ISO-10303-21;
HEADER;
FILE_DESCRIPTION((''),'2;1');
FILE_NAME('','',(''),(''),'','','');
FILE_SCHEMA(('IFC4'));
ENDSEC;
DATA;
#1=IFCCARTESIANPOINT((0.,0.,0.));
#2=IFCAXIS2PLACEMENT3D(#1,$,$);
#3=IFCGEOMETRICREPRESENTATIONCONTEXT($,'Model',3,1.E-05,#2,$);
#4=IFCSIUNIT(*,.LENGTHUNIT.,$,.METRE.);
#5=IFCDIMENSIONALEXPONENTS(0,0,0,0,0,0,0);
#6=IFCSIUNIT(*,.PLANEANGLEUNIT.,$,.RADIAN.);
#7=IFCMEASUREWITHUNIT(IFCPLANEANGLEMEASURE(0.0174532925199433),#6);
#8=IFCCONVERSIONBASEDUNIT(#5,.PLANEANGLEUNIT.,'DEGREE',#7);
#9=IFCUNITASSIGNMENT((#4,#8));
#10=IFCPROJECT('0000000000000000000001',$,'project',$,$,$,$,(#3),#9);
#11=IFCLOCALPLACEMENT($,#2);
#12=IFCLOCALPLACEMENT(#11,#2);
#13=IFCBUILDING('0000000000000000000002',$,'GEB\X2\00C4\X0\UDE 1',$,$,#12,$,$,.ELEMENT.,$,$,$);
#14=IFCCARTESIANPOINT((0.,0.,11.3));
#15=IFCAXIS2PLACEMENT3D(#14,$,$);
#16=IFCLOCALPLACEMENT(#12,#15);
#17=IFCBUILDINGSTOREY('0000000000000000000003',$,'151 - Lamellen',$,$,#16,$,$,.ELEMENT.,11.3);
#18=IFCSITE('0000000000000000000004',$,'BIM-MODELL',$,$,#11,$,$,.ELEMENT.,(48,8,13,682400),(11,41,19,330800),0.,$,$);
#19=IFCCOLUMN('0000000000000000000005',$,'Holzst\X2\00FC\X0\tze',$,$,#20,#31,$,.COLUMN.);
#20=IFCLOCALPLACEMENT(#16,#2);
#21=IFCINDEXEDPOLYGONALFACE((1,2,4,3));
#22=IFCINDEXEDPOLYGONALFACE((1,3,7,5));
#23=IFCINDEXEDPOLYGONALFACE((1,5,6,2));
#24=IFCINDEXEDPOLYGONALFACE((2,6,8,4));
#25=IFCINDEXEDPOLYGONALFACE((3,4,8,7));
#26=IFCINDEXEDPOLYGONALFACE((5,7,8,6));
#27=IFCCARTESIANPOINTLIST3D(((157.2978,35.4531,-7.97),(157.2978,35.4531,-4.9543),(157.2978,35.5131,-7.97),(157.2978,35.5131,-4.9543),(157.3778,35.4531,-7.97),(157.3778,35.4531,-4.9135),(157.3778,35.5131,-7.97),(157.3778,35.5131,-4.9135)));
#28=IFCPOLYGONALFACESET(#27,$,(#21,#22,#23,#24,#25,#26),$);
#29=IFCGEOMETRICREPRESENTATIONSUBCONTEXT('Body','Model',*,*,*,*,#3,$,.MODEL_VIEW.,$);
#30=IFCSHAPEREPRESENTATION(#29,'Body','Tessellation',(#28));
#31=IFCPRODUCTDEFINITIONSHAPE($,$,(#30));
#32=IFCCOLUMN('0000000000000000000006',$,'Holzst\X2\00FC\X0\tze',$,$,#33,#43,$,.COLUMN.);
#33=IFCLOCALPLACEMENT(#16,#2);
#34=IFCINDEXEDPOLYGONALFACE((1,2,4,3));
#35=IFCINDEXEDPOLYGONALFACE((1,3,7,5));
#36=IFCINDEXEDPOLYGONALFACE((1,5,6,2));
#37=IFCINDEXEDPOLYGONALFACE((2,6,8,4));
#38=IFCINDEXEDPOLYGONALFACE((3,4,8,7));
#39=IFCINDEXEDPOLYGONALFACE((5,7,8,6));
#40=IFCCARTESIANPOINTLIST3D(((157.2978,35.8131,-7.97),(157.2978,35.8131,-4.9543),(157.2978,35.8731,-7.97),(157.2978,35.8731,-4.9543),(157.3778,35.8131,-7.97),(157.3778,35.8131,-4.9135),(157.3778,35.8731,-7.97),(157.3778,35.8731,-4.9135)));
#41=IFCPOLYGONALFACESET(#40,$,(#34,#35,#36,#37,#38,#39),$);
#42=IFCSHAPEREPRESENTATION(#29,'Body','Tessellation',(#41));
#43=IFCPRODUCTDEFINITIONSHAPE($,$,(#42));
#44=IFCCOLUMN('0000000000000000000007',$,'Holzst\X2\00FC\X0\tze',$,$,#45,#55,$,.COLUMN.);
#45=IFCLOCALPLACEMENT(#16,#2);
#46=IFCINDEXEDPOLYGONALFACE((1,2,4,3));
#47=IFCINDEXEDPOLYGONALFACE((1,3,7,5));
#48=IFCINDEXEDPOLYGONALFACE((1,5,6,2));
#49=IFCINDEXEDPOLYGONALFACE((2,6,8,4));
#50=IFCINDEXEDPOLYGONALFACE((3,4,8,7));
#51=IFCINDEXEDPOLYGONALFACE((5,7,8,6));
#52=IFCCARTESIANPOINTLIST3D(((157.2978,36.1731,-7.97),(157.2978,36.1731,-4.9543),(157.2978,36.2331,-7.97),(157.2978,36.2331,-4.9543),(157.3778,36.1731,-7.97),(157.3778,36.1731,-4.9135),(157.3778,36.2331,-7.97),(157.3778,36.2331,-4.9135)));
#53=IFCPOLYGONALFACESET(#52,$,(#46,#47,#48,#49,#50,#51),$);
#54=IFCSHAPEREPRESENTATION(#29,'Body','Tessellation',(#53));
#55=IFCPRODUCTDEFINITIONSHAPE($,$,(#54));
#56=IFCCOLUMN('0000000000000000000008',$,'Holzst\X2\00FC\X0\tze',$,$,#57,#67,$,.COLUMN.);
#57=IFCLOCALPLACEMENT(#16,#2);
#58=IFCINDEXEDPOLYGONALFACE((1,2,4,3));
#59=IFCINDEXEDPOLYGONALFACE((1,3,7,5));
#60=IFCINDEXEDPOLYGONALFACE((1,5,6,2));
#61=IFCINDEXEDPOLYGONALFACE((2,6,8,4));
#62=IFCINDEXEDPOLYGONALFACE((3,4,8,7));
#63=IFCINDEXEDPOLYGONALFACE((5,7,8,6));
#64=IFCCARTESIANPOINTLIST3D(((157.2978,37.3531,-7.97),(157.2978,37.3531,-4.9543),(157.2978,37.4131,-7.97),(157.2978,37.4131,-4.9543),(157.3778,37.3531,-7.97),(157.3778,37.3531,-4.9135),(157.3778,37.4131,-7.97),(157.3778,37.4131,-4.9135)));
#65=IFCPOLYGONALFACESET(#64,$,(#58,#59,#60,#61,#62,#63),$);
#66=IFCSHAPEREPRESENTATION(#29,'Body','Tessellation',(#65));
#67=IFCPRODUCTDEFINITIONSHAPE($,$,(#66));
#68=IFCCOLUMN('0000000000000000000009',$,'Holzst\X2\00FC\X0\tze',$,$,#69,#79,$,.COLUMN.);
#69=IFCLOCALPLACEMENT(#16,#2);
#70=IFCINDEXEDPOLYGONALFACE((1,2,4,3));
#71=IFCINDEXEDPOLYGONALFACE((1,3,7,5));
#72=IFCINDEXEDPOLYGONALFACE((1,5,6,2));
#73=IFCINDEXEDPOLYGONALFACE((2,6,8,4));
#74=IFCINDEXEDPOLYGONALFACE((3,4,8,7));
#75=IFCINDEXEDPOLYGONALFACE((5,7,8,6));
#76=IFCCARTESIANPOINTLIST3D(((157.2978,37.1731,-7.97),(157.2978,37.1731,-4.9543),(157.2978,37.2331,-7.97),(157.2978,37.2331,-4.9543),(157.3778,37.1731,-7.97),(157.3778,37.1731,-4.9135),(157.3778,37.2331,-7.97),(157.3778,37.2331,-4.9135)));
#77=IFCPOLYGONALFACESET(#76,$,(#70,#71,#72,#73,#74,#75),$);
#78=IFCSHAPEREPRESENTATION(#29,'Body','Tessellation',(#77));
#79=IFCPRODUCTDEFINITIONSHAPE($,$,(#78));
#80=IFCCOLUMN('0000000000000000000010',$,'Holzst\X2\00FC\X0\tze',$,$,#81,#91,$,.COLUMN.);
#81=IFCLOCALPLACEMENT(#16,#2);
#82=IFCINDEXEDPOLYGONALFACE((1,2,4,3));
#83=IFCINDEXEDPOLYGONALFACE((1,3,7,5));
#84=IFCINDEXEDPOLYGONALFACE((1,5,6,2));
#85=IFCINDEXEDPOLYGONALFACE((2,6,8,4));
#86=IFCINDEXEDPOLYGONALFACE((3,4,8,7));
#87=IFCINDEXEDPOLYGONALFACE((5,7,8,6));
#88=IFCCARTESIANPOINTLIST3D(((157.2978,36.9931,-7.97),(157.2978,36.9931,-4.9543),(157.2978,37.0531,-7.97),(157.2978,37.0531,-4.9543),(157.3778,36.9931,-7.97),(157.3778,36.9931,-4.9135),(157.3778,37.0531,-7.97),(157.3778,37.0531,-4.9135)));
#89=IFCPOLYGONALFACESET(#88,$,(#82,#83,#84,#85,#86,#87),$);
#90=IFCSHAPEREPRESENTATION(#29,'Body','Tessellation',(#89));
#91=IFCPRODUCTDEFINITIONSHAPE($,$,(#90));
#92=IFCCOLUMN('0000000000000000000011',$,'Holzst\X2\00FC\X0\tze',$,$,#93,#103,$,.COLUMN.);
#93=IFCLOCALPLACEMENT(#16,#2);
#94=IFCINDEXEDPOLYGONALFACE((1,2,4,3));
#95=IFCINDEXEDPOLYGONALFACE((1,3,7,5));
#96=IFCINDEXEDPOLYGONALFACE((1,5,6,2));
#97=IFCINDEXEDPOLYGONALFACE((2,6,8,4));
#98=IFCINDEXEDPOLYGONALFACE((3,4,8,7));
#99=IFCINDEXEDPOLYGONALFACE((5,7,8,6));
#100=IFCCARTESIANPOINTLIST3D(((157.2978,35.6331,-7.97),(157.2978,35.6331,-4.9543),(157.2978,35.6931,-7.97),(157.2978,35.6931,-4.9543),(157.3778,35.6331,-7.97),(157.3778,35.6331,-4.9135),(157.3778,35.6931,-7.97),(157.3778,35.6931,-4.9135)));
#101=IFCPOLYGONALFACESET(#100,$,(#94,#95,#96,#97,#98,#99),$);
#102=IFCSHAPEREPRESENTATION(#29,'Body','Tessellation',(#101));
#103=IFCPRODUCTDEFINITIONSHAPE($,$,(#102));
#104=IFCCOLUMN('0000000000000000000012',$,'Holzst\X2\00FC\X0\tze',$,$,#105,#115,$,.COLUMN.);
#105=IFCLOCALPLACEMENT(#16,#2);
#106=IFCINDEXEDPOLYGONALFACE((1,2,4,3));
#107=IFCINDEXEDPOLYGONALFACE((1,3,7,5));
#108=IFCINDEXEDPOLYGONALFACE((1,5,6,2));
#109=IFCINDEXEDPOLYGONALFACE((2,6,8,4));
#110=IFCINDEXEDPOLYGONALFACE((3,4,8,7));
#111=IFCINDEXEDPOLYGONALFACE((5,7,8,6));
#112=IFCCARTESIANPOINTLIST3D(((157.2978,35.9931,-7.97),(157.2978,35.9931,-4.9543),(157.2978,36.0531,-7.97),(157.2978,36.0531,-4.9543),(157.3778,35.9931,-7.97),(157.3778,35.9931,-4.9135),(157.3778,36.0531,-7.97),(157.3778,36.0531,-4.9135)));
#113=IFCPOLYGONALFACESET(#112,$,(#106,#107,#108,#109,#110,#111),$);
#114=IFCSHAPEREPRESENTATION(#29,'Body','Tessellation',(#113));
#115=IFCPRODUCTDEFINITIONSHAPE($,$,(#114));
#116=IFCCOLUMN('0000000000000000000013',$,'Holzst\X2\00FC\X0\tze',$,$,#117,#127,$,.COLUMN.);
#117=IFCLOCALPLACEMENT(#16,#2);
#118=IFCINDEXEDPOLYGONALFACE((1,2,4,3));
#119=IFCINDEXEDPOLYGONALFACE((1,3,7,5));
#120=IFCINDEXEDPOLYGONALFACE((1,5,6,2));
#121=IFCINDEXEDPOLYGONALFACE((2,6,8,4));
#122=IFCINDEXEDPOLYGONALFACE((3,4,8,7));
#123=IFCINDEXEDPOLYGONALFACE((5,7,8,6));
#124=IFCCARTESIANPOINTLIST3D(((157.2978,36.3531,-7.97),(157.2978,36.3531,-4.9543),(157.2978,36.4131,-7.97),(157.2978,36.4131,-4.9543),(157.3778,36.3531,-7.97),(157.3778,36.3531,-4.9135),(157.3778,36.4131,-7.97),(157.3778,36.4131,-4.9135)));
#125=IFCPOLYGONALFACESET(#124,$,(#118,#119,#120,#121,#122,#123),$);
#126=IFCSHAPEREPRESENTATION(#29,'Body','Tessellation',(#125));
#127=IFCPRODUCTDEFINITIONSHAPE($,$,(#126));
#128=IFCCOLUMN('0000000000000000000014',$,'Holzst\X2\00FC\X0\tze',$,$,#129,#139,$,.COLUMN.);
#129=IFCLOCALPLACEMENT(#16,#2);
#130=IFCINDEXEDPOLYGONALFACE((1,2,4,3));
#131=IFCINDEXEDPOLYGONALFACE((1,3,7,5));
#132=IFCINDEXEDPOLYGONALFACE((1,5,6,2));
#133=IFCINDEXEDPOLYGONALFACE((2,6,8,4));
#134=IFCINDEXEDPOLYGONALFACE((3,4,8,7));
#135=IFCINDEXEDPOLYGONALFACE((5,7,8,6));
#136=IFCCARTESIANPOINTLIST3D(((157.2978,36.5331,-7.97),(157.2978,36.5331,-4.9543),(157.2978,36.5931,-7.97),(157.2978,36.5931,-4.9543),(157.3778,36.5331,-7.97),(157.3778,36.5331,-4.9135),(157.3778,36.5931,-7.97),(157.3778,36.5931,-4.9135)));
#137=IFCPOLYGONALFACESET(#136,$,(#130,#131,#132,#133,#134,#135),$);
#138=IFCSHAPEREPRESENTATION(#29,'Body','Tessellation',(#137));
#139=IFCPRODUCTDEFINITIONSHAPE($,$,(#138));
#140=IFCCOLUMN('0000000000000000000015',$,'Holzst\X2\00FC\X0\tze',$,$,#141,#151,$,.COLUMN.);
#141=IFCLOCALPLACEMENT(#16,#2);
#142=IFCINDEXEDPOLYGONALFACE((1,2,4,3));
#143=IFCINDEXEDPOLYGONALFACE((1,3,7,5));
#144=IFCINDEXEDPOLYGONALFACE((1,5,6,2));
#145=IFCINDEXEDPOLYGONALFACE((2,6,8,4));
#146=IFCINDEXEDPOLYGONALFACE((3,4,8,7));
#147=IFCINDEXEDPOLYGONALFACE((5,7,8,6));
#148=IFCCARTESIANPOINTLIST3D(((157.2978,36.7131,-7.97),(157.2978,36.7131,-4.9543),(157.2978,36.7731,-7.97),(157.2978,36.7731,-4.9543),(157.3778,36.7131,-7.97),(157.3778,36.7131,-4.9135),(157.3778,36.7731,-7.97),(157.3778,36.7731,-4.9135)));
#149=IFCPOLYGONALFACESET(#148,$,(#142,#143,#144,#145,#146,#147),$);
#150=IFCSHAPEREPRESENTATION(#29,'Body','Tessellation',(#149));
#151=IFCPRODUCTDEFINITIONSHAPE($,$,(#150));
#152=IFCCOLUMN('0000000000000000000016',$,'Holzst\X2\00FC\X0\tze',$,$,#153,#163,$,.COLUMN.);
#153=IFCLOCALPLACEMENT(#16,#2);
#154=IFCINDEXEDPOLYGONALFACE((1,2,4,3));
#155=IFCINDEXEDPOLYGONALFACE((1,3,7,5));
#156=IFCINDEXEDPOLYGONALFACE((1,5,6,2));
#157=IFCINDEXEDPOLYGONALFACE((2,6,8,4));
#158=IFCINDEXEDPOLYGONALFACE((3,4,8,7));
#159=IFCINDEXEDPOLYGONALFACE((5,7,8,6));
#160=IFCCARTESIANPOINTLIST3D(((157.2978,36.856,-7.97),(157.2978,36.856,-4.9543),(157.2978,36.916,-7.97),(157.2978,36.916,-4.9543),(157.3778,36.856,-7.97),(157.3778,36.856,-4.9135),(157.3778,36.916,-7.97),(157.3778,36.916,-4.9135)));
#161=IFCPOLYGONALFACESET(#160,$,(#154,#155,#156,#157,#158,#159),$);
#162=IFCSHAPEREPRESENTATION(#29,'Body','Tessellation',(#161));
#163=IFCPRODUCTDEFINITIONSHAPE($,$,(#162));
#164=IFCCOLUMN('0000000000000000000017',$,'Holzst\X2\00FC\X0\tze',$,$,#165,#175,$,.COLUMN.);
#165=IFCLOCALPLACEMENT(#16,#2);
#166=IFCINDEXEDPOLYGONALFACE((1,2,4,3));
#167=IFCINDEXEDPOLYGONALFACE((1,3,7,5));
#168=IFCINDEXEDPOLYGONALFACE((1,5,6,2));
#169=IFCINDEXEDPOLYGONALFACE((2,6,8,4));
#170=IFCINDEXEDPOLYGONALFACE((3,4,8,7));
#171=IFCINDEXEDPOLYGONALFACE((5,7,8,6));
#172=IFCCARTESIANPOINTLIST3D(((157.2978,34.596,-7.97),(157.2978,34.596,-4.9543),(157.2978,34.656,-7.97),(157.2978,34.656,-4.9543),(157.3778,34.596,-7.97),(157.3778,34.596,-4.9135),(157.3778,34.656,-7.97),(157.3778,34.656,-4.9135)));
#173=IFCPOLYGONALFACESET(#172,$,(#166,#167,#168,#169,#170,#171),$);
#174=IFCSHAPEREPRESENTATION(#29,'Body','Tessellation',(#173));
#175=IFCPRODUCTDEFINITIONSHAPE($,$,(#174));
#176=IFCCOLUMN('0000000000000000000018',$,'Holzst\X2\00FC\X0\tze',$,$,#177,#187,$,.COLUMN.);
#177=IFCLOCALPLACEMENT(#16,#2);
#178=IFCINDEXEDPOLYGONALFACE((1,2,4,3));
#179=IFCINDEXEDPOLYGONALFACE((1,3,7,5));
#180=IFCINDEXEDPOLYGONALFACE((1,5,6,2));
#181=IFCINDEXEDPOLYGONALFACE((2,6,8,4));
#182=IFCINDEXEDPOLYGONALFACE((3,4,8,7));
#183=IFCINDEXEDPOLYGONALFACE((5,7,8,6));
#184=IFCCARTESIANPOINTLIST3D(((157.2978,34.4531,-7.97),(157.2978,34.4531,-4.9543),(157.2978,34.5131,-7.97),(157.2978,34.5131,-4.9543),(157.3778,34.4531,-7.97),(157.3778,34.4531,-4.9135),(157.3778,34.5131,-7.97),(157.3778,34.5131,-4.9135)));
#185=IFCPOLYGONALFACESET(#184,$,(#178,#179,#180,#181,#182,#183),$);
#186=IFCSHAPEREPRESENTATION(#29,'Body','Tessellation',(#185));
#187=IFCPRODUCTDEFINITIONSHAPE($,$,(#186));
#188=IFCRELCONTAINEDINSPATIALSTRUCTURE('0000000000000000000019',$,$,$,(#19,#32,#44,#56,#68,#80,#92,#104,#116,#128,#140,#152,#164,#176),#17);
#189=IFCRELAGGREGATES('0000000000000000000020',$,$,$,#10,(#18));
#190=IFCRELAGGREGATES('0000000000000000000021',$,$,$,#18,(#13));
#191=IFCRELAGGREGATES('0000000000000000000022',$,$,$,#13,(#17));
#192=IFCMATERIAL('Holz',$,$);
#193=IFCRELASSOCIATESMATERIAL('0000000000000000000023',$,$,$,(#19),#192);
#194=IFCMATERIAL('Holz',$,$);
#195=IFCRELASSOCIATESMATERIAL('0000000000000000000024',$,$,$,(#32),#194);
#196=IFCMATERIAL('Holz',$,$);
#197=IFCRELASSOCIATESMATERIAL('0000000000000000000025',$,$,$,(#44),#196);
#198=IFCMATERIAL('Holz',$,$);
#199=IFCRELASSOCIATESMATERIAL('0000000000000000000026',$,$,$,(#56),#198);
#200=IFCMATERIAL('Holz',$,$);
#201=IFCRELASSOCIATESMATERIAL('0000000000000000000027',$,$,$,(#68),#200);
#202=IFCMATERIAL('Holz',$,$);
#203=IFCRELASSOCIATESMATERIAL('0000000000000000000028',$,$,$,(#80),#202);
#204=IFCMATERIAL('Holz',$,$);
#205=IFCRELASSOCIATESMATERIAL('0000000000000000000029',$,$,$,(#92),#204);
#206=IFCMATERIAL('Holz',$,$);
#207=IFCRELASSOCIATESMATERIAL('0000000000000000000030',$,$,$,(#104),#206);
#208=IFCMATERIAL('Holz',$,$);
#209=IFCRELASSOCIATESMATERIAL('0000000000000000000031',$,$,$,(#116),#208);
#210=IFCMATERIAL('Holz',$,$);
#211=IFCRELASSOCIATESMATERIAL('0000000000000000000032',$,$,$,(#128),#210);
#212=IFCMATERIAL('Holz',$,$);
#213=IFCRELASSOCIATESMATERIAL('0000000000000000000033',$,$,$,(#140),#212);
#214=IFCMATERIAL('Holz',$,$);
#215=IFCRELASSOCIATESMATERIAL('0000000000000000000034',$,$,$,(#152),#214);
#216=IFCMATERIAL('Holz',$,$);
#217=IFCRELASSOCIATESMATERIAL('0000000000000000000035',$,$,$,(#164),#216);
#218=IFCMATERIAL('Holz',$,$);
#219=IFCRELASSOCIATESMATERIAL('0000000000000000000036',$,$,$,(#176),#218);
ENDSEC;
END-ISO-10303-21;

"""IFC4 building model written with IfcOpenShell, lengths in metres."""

from ifc_helpers import new_model, entity, si_unit, converted_unit, frame, frame_2d, origin, origin_with_axes, place, context, subcontext, project, spatial, rectangle, extrude, clip, halfspace, material, element, save


model = new_model("IFC4")

# Units and contexts
model_context = context("Model", 3, precision=1e-05, world=origin())
body_context = subcontext(model_context, "Body", "Model", "MODEL_VIEW")
ifc_project = project(units=[si_unit("LENGTHUNIT", "METRE"), converted_unit("PLANEANGLEUNIT", "DEGREE", entity("IfcPlaneAngleMeasure", 0.0174532925199433), si_unit("PLANEANGLEUNIT", "RADIAN"), dimensions=[0, 0, 0, 0, 0, 0, 0])], contexts=[model_context])

# Site, building, storey
site_placement = place(None, origin())
site = spatial("IfcSite", under=ifc_project, at=site_placement, Name="BIM-MODELL", CompositionType="ELEMENT", RefLatitude=(48, 8, 13, 682400), RefLongitude=(11, 41, 19, 330800), RefElevation=0.0)
building_placement = place(site_placement, origin())
building = spatial("IfcBuilding", under=site, at=building_placement, Name="GEBÄUDE 1", CompositionType="ELEMENT")
storey_placement = place(building_placement, frame((0.0, 0.0, 11.3)))
storey = spatial("IfcBuildingStorey", under=building, at=storey_placement, Name="151 - Lamellen", CompositionType="ELEMENT", Elevation=11.3)

# Columns
ifc_material_1 = material(Name="Holz")
column_1_placement = place(storey_placement, frame((157.3778, 35.4531, -7.97)))
element("IfcColumn", 1, at=column_1_placement, inside=storey, material=ifc_material_1, Name="Holzstütze", PredefinedType="COLUMN", context=body_context, shape_type="Clipping", body=[
    clip(extrude(rectangle(XDim=0.06, YDim=0.08, at=frame_2d((-0.04, 0.03), x_axis=(0.0, 1.0))), origin_with_axes(), (0.0, 0.0, 1.0), 3.0565), halfspace(frame((-0.04, 0.03, 3.0361), z_axis=(0.45399, 0.0, -0.891007), x_axis=(-0.891007, 0.0, -0.45399)), True)),
])
ifc_material_2 = material(Name="Holz")
column_2_placement = place(storey_placement, frame((157.3778, 35.8131, -7.97)))
element("IfcColumn", 2, at=column_2_placement, inside=storey, material=ifc_material_2, Name="Holzstütze", PredefinedType="COLUMN", context=body_context, shape_type="Clipping", body=[
    clip(extrude(rectangle(XDim=0.06, YDim=0.08, at=frame_2d((-0.04, 0.03), x_axis=(0.0, 1.0))), origin_with_axes(), (0.0, 0.0, 1.0), 3.0565), halfspace(frame((-0.04, 0.03, 3.0361), z_axis=(0.45399, 0.0, -0.891007), x_axis=(-0.891007, 0.0, -0.45399)), True)),
])
ifc_material_3 = material(Name="Holz")
column_3_placement = place(storey_placement, frame((157.3778, 36.1731, -7.97)))
element("IfcColumn", 3, at=column_3_placement, inside=storey, material=ifc_material_3, Name="Holzstütze", PredefinedType="COLUMN", context=body_context, shape_type="Clipping", body=[
    clip(extrude(rectangle(XDim=0.06, YDim=0.08, at=frame_2d((-0.04, 0.03), x_axis=(0.0, 1.0))), origin_with_axes(), (0.0, 0.0, 1.0), 3.0565), halfspace(frame((-0.04, 0.03, 3.0361), z_axis=(0.45399, 0.0, -0.891007), x_axis=(-0.891007, 0.0, -0.45399)), True)),
])
ifc_material_4 = material(Name="Holz")
column_4_placement = place(storey_placement, frame((157.3778, 37.3531, -7.97)))
element("IfcColumn", 4, at=column_4_placement, inside=storey, material=ifc_material_4, Name="Holzstütze", PredefinedType="COLUMN", context=body_context, shape_type="Clipping", body=[
    clip(extrude(rectangle(XDim=0.06, YDim=0.08, at=frame_2d((-0.04, 0.03), x_axis=(0.0, 1.0))), origin_with_axes(), (0.0, 0.0, 1.0), 3.0565), halfspace(frame((-0.04, 0.03, 3.0361), z_axis=(0.45399, 0.0, -0.891007), x_axis=(-0.891007, 0.0, -0.45399)), True)),
])
ifc_material_5 = material(Name="Holz")
column_5_placement = place(storey_placement, frame((157.3778, 37.1731, -7.97)))
element("IfcColumn", 5, at=column_5_placement, inside=storey, material=ifc_material_5, Name="Holzstütze", PredefinedType="COLUMN", context=body_context, shape_type="Clipping", body=[
    clip(extrude(rectangle(XDim=0.06, YDim=0.08, at=frame_2d((-0.04, 0.03), x_axis=(0.0, 1.0))), origin_with_axes(), (0.0, 0.0, 1.0), 3.0565), halfspace(frame((-0.04, 0.03, 3.0361), z_axis=(0.45399, 0.0, -0.891007), x_axis=(-0.891007, 0.0, -0.45399)), True)),
])
ifc_material_6 = material(Name="Holz")
column_6_placement = place(storey_placement, frame((157.3778, 36.9931, -7.97)))
element("IfcColumn", 6, at=column_6_placement, inside=storey, material=ifc_material_6, Name="Holzstütze", PredefinedType="COLUMN", context=body_context, shape_type="Clipping", body=[
    clip(extrude(rectangle(XDim=0.06, YDim=0.08, at=frame_2d((-0.04, 0.03), x_axis=(0.0, 1.0))), origin_with_axes(), (0.0, 0.0, 1.0), 3.0565), halfspace(frame((-0.04, 0.03, 3.0361), z_axis=(0.45399, 0.0, -0.891007), x_axis=(-0.891007, 0.0, -0.45399)), True)),
])
ifc_material_7 = material(Name="Holz")
column_7_placement = place(storey_placement, frame((157.3778, 35.6331, -7.97)))
element("IfcColumn", 7, at=column_7_placement, inside=storey, material=ifc_material_7, Name="Holzstütze", PredefinedType="COLUMN", context=body_context, shape_type="Clipping", body=[
    clip(extrude(rectangle(XDim=0.06, YDim=0.08, at=frame_2d((-0.04, 0.03), x_axis=(0.0, 1.0))), origin_with_axes(), (0.0, 0.0, 1.0), 3.0565), halfspace(frame((-0.04, 0.03, 3.0361), z_axis=(0.45399, 0.0, -0.891007), x_axis=(-0.891007, 0.0, -0.45399)), True)),
])
ifc_material_8 = material(Name="Holz")
column_8_placement = place(storey_placement, frame((157.3778, 35.9931, -7.97)))
element("IfcColumn", 8, at=column_8_placement, inside=storey, material=ifc_material_8, Name="Holzstütze", PredefinedType="COLUMN", context=body_context, shape_type="Clipping", body=[
    clip(extrude(rectangle(XDim=0.06, YDim=0.08, at=frame_2d((-0.04, 0.03), x_axis=(0.0, 1.0))), origin_with_axes(), (0.0, 0.0, 1.0), 3.0565), halfspace(frame((-0.04, 0.03, 3.0361), z_axis=(0.45399, 0.0, -0.891007), x_axis=(-0.891007, 0.0, -0.45399)), True)),
])
ifc_material_9 = material(Name="Holz")
column_9_placement = place(storey_placement, frame((157.3778, 36.3531, -7.97)))
element("IfcColumn", 9, at=column_9_placement, inside=storey, material=ifc_material_9, Name="Holzstütze", PredefinedType="COLUMN", context=body_context, shape_type="Clipping", body=[
    clip(extrude(rectangle(XDim=0.06, YDim=0.08, at=frame_2d((-0.04, 0.03), x_axis=(0.0, 1.0))), origin_with_axes(), (0.0, 0.0, 1.0), 3.0565), halfspace(frame((-0.04, 0.03, 3.0361), z_axis=(0.45399, 0.0, -0.891007), x_axis=(-0.891007, 0.0, -0.45399)), True)),
])
ifc_material_10 = material(Name="Holz")
column_10_placement = place(storey_placement, frame((157.3778, 36.5331, -7.97)))
element("IfcColumn", 10, at=column_10_placement, inside=storey, material=ifc_material_10, Name="Holzstütze", PredefinedType="COLUMN", context=body_context, shape_type="Clipping", body=[
    clip(extrude(rectangle(XDim=0.06, YDim=0.08, at=frame_2d((-0.04, 0.03), x_axis=(0.0, 1.0))), origin_with_axes(), (0.0, 0.0, 1.0), 3.0565), halfspace(frame((-0.04, 0.03, 3.0361), z_axis=(0.45399, 0.0, -0.891007), x_axis=(-0.891007, 0.0, -0.45399)), True)),
])
ifc_material_11 = material(Name="Holz")
column_11_placement = place(storey_placement, frame((157.3778, 36.7131, -7.97)))
element("IfcColumn", 11, at=column_11_placement, inside=storey, material=ifc_material_11, Name="Holzstütze", PredefinedType="COLUMN", context=body_context, shape_type="Clipping", body=[
    clip(extrude(rectangle(XDim=0.06, YDim=0.08, at=frame_2d((-0.04, 0.03), x_axis=(0.0, 1.0))), origin_with_axes(), (0.0, 0.0, 1.0), 3.0565), halfspace(frame((-0.04, 0.03, 3.0361), z_axis=(0.45399, 0.0, -0.891007), x_axis=(-0.891007, 0.0, -0.45399)), True)),
])
ifc_material_12 = material(Name="Holz")
column_12_placement = place(storey_placement, frame((157.3778, 36.856, -7.97)))
element("IfcColumn", 12, at=column_12_placement, inside=storey, material=ifc_material_12, Name="Holzstütze", PredefinedType="COLUMN", context=body_context, shape_type="Clipping", body=[
    clip(extrude(rectangle(XDim=0.06, YDim=0.08, at=frame_2d((-0.04, 0.03), x_axis=(0.0, 1.0))), origin_with_axes(), (0.0, 0.0, 1.0), 3.0565), halfspace(frame((-0.04, 0.03, 3.0361), z_axis=(0.45399, 0.0, -0.891007), x_axis=(-0.891007, 0.0, -0.45399)), True)),
])
ifc_material_13 = material(Name="Holz")
column_13_placement = place(storey_placement, frame((157.3778, 34.596, -7.97)))
element("IfcColumn", 13, at=column_13_placement, inside=storey, material=ifc_material_13, Name="Holzstütze", PredefinedType="COLUMN", context=body_context, shape_type="Clipping", body=[
    clip(extrude(rectangle(XDim=0.06, YDim=0.08, at=frame_2d((-0.04, 0.03), x_axis=(0.0, 1.0))), origin_with_axes(), (0.0, 0.0, 1.0), 3.0565), halfspace(frame((-0.04, 0.03, 3.0361), z_axis=(0.45399, 0.0, -0.891007), x_axis=(-0.891007, 0.0, -0.45399)), True)),
])
ifc_material_14 = material(Name="Holz")
column_14_placement = place(storey_placement, frame((157.3778, 34.4531, -7.97)))
element("IfcColumn", 14, at=column_14_placement, inside=storey, material=ifc_material_14, Name="Holzstütze", PredefinedType="COLUMN", context=body_context, shape_type="Clipping", body=[
    clip(extrude(rectangle(XDim=0.06, YDim=0.08, at=frame_2d((-0.04, 0.03), x_axis=(0.0, 1.0))), origin_with_axes(), (0.0, 0.0, 1.0), 3.0565), halfspace(frame((-0.04, 0.03, 3.0361), z_axis=(0.45399, 0.0, -0.891007), x_axis=(-0.891007, 0.0, -0.45399)), True)),
])

save(model, "model.ifc")
